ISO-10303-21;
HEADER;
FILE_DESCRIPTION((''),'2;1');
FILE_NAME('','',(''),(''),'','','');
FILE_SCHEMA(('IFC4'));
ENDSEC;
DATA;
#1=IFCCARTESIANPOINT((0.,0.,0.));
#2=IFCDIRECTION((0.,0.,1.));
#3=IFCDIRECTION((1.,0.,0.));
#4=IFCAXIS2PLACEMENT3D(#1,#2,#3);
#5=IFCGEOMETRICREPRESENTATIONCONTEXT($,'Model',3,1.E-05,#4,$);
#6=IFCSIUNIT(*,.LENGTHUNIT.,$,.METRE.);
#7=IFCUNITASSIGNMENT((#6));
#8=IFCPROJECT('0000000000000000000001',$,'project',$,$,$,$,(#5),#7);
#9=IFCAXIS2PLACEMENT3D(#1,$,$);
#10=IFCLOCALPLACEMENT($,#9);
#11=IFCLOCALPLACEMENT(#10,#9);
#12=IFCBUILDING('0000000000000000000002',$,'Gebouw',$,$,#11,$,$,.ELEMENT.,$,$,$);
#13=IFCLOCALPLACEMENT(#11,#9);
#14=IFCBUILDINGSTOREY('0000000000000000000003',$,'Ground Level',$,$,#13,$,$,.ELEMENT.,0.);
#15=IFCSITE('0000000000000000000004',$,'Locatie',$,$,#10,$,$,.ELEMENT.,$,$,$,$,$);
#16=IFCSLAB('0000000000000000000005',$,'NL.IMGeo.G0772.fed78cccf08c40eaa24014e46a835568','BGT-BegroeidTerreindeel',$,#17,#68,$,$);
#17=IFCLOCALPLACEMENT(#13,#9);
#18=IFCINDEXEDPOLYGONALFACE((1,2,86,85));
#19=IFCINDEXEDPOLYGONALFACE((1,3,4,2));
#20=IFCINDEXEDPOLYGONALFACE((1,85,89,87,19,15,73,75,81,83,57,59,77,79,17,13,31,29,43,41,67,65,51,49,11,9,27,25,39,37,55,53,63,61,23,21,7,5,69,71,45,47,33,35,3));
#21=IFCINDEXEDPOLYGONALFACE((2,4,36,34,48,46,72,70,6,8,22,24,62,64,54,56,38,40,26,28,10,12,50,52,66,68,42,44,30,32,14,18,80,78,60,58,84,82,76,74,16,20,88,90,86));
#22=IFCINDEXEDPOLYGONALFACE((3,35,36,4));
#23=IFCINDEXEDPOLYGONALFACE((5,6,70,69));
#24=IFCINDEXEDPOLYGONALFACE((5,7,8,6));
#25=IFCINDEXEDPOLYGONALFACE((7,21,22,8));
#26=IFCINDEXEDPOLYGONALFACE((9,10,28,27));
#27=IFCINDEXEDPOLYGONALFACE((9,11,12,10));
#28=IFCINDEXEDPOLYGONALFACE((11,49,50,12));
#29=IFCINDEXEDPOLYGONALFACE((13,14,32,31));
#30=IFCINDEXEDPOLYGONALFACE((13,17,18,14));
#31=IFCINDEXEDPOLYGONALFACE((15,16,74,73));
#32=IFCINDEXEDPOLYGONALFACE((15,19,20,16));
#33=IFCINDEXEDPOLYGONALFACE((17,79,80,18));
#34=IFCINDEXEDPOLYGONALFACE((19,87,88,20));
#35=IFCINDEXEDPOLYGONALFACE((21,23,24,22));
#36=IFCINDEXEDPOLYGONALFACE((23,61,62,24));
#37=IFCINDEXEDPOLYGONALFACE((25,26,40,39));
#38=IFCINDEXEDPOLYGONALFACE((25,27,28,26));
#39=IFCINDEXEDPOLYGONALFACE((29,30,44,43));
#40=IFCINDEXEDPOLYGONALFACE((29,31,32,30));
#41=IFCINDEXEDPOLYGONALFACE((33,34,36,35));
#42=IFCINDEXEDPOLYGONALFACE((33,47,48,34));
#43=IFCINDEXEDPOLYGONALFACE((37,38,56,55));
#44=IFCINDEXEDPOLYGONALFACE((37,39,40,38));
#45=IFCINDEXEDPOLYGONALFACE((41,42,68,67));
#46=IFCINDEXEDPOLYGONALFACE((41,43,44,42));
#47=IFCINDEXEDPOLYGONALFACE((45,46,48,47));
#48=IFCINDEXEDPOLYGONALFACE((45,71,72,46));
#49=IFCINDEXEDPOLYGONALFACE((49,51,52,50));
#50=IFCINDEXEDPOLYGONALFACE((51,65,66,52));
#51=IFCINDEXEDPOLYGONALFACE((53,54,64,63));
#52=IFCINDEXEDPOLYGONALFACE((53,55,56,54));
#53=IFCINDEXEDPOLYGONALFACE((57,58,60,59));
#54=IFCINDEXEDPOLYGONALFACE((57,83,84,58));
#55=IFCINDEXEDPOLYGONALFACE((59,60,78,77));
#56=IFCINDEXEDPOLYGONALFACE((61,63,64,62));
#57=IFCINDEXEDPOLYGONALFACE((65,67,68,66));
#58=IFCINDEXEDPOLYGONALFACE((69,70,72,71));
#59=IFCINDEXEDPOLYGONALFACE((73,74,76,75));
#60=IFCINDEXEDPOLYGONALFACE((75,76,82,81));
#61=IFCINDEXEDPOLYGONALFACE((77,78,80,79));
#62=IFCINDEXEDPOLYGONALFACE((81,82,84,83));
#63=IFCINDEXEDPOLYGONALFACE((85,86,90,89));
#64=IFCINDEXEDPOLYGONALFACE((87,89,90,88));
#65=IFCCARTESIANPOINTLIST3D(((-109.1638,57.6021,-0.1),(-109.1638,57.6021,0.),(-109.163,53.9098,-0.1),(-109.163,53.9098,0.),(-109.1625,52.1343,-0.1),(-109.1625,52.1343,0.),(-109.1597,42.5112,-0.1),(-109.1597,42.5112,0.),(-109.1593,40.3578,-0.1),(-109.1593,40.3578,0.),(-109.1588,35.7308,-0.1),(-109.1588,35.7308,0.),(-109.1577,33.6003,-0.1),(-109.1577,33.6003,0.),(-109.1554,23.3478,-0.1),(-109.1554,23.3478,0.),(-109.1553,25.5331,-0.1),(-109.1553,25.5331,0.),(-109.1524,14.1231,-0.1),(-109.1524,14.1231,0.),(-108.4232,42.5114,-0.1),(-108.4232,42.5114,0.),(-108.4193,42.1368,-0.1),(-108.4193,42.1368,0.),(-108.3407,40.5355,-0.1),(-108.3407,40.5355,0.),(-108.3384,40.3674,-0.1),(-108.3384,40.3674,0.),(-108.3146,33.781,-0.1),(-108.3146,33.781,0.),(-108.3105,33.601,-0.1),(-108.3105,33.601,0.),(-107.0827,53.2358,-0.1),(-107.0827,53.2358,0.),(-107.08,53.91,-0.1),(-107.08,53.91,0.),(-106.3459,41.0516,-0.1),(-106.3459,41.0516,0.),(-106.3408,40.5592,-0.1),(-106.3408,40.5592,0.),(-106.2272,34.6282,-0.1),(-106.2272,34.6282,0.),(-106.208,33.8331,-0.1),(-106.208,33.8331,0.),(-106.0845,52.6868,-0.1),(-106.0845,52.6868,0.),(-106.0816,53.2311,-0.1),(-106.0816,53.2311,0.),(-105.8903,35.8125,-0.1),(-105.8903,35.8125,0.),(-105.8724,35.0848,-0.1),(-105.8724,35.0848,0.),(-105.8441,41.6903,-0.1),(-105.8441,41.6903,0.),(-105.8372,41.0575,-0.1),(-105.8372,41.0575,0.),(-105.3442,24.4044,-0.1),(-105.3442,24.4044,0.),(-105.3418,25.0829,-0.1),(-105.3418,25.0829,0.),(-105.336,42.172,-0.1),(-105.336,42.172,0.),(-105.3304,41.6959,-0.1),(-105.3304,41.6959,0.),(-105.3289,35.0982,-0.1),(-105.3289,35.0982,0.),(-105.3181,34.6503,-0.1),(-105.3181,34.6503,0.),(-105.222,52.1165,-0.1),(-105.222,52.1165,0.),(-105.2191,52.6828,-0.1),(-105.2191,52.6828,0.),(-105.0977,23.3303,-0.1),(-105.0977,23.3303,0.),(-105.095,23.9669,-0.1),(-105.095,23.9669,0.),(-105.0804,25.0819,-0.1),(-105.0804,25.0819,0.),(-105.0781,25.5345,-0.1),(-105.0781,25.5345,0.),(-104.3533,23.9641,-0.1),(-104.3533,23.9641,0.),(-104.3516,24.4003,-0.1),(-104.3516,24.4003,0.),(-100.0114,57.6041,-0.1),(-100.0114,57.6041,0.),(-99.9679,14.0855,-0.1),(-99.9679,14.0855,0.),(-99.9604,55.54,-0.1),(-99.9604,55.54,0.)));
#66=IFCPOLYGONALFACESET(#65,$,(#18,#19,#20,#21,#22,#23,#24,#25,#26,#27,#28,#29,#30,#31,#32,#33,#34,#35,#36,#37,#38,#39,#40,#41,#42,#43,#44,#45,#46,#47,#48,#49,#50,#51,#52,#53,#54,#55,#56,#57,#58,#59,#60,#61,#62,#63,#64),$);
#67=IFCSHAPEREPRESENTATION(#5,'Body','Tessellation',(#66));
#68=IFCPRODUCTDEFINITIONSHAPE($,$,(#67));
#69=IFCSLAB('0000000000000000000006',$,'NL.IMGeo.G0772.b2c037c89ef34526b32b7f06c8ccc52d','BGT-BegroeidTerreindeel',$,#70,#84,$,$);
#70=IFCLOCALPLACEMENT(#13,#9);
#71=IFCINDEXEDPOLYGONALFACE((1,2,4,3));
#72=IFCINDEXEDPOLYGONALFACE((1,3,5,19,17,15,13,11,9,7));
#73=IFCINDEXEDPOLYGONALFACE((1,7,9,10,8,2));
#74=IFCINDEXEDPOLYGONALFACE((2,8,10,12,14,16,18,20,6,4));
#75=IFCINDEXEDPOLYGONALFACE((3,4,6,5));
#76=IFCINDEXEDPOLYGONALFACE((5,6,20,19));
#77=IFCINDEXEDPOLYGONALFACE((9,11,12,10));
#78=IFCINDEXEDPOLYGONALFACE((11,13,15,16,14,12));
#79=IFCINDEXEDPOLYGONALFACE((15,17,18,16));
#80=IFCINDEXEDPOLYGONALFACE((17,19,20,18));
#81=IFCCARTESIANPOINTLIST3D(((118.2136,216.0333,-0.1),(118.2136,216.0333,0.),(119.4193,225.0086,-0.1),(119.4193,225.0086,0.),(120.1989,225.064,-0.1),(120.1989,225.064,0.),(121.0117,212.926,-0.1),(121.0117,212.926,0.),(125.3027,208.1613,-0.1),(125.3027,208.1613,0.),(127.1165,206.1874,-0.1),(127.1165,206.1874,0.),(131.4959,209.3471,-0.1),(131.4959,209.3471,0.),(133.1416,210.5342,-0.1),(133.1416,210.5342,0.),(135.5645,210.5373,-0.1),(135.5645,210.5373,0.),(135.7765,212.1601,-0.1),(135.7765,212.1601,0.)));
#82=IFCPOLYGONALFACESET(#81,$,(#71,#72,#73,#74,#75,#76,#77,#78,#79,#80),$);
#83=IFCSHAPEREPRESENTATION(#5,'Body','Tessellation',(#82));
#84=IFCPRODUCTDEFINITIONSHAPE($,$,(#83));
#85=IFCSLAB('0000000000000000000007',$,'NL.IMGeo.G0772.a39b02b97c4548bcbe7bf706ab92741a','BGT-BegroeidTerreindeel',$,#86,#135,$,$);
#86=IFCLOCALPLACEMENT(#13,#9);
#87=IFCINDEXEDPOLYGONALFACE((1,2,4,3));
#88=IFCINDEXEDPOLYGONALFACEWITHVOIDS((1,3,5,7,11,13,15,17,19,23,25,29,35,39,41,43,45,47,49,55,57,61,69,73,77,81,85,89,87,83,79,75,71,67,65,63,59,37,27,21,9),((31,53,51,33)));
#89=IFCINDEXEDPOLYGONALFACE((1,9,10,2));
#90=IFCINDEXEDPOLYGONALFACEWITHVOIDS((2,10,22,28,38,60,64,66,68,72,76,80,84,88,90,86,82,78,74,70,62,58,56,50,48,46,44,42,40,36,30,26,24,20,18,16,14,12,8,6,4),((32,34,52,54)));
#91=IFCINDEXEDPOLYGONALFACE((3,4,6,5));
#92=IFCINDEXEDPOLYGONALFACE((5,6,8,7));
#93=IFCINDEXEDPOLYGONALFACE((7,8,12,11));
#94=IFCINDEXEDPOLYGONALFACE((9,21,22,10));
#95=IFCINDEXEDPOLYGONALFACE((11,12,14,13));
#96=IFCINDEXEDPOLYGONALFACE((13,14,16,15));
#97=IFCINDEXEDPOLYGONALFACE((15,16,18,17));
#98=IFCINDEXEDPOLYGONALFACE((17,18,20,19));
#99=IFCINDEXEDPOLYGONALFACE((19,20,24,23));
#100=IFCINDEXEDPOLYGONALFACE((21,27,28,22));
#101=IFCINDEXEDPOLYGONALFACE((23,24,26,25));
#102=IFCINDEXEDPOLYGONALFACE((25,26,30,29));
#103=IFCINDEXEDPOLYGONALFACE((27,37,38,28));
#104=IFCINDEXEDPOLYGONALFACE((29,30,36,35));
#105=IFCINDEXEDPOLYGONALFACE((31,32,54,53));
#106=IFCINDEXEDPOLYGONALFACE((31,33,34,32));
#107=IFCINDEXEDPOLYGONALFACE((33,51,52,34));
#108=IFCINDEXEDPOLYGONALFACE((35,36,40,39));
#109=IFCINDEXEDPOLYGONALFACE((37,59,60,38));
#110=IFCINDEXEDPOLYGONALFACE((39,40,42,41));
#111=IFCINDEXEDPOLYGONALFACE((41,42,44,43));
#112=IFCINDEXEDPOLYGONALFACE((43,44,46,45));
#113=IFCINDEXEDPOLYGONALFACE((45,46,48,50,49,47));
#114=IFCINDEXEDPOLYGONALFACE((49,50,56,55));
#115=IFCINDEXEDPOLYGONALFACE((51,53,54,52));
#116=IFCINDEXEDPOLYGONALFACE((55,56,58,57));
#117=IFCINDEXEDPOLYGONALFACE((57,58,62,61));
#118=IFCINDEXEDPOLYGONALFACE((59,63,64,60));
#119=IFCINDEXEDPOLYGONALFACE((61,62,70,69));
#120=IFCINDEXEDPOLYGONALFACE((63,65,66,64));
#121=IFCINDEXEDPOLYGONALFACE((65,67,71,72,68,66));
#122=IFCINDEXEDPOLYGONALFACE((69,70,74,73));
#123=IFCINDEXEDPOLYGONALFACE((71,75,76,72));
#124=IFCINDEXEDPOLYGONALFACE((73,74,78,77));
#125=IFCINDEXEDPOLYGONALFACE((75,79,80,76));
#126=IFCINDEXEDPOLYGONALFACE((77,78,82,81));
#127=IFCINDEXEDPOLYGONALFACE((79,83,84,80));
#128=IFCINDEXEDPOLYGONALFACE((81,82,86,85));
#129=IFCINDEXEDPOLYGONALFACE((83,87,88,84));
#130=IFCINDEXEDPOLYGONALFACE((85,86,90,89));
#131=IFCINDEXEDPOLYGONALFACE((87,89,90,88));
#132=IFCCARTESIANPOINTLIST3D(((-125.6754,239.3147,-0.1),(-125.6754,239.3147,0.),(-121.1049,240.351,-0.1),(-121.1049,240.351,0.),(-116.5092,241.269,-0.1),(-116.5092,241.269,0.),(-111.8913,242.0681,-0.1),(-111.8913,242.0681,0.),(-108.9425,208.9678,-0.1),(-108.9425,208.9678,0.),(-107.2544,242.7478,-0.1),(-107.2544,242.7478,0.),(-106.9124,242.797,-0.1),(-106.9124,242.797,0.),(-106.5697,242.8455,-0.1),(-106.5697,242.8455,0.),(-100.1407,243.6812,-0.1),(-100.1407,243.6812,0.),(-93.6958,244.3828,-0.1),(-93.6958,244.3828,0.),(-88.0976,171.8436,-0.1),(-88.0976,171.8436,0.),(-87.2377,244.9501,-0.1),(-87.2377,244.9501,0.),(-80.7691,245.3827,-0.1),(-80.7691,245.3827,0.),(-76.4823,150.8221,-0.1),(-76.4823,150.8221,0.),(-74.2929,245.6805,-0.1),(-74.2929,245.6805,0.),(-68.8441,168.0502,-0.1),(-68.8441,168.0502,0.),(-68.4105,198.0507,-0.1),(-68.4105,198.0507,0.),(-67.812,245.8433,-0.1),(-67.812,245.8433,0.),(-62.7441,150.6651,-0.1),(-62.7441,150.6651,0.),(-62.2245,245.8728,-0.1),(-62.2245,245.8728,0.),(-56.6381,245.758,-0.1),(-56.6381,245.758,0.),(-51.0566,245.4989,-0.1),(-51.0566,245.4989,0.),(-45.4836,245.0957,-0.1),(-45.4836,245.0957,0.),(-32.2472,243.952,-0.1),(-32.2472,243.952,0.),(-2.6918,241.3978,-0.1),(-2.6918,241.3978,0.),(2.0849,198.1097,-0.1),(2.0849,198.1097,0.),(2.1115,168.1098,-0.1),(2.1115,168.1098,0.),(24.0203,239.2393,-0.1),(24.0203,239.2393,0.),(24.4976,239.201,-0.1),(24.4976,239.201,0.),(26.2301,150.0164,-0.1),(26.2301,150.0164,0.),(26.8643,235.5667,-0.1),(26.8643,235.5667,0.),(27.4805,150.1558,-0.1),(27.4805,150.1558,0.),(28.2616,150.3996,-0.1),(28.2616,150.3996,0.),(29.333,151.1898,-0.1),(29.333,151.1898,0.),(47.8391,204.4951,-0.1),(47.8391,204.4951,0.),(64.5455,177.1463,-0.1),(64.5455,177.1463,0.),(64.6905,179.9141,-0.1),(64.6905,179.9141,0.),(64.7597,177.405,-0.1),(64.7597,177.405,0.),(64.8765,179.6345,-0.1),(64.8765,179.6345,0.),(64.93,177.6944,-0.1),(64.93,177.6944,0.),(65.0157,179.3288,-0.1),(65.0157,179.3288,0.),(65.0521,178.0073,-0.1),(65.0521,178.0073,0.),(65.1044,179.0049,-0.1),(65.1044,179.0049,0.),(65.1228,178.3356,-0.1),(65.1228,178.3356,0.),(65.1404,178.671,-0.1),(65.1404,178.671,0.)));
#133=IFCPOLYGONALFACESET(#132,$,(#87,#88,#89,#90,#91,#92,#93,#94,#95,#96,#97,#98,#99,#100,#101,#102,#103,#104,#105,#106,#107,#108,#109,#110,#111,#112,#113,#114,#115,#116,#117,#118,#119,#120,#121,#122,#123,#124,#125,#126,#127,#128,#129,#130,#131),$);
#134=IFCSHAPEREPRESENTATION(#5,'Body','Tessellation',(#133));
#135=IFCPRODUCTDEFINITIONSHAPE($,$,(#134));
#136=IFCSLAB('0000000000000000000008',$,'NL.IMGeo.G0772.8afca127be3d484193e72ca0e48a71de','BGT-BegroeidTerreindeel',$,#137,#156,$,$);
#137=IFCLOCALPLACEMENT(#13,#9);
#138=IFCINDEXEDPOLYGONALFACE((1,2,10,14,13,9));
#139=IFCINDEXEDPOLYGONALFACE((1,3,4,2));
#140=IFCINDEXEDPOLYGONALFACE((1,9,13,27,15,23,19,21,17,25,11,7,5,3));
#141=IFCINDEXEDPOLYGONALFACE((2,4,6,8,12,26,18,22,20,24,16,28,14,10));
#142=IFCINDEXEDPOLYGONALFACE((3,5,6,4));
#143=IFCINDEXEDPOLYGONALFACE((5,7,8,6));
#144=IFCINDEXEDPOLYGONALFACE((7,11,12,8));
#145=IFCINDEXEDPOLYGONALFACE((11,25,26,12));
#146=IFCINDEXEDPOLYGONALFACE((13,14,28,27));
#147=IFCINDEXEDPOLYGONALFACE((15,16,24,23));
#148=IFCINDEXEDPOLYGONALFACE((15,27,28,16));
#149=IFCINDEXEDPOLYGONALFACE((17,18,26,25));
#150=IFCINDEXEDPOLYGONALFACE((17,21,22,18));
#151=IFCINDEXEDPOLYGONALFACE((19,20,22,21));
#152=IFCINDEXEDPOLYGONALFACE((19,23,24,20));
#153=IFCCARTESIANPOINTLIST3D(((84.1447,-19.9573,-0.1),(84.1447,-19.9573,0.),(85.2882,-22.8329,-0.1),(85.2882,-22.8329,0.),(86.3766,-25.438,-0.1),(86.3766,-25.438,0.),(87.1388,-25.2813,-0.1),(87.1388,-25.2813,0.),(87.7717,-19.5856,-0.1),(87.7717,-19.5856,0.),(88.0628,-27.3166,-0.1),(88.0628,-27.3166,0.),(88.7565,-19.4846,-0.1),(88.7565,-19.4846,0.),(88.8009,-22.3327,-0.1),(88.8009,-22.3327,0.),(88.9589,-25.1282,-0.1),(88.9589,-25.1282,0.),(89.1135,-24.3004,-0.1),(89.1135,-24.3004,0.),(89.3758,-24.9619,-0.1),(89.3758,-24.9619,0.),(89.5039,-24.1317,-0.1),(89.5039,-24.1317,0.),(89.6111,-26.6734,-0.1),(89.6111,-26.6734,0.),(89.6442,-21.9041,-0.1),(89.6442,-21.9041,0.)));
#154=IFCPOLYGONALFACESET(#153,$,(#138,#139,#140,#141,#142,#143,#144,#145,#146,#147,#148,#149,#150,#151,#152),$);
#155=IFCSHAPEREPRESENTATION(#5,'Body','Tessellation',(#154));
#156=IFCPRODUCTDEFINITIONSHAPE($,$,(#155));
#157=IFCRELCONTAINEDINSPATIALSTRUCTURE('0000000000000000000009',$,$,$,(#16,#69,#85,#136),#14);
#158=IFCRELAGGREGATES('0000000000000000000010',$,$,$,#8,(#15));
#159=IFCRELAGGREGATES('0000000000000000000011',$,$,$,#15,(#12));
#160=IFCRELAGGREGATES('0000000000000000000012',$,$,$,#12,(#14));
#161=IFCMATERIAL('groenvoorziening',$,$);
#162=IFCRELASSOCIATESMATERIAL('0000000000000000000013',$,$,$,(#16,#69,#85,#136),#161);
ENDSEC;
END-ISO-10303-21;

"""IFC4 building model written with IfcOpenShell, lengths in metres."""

from ifc_helpers import new_model, si_unit, frame, origin, origin_with_axes, place, context, project, spatial, polyline, outline, extrude, material, element, save


model = new_model("IFC4")

# Units and contexts
model_context = context("Model", 3, precision=1e-05, world=origin_with_axes())
ifc_project = project(units=[si_unit("LENGTHUNIT", "METRE")], contexts=[model_context])

# Site, building, storey
site_placement = place(None, origin())
site = spatial("IfcSite", under=ifc_project, at=site_placement, Name="Locatie", CompositionType="ELEMENT")
building_placement = place(site_placement, origin())
building = spatial("IfcBuilding", under=site, at=building_placement, Name="Gebouw", CompositionType="ELEMENT")
storey_placement = place(building_placement, origin())
storey = spatial("IfcBuildingStorey", under=building, at=storey_placement, Name="Ground Level", CompositionType="ELEMENT", Elevation=0.0)

# Slabs
ifc_material = material(Name="groenvoorziening")
slab_1_placement = place(storey_placement, origin())
element("IfcSlab", 1, at=slab_1_placement, inside=storey, material=ifc_material, Name="NL.IMGeo.G0772.fed78cccf08c40eaa24014e46a835568", Description="BGT-BegroeidTerreindeel", context=model_context, shape_type="SweptSolid", body=[
    extrude(outline(polyline([(-99.9679, 14.0855), (-109.1524, 14.1231), (-109.1554, 23.3478), (-105.0977, 23.3303), (-105.095, 23.9669), (-104.3533, 23.9641), (-104.3516, 24.4003), (-105.3442, 24.4044), (-105.3418, 25.0829), (-105.0804, 25.0819), (-105.0781, 25.5345), (-109.1553, 25.5331), (-109.1577, 33.6003), (-108.3105, 33.601), (-108.3146, 33.781), (-106.208, 33.8331), (-106.2272, 34.6282), (-105.3181, 34.6503), (-105.3289, 35.0982), (-105.8724, 35.0848), (-105.8903, 35.8125), (-109.1588, 35.7308), (-109.1593, 40.3578), (-108.3384, 40.3674), (-108.3407, 40.5355), (-106.3408, 40.5592), (-106.3459, 41.0516), (-105.8372, 41.0575), (-105.8441, 41.6903), (-105.3304, 41.6959), (-105.336, 42.172), (-108.4193, 42.1368), (-108.4232, 42.5114), (-109.1597, 42.5112), (-109.1625, 52.1343), (-105.222, 52.1165), (-105.2191, 52.6828), (-106.0845, 52.6868), (-106.0816, 53.2311), (-107.0827, 53.2358), (-107.08, 53.91), (-109.163, 53.9098), (-109.1638, 57.6021), (-100.0114, 57.6041), (-99.9604, 55.54), (-99.9679, 14.0855)])), frame((0.0, 0.0, -0.1), z_axis=(0.0, 0.0, 1.0), x_axis=(1.0, 0.0, 0.0)), (0.0, 0.0, 1.0), 0.1),
])
slab_2_placement = place(storey_placement, origin())
element("IfcSlab", 2, at=slab_2_placement, inside=storey, material=ifc_material, Name="NL.IMGeo.G0772.b2c037c89ef34526b32b7f06c8ccc52d", Description="BGT-BegroeidTerreindeel", context=model_context, shape_type="SweptSolid", body=[
    extrude(outline(polyline([(135.5645, 210.5373), (133.1416, 210.5342), (131.4959, 209.3471), (127.1165, 206.1874), (125.3027, 208.1613), (121.0117, 212.926), (118.2136, 216.0333), (119.4193, 225.0086), (120.1989, 225.064), (135.7765, 212.1601), (135.5645, 210.5373)])), frame((0.0, 0.0, -0.1), z_axis=(0.0, 0.0, 1.0), x_axis=(1.0, 0.0, 0.0)), (0.0, 0.0, 1.0), 0.1),
])
slab_3_placement = place(storey_placement, origin())
element("IfcSlab", 3, at=slab_3_placement, inside=storey, material=ifc_material, Name="NL.IMGeo.G0772.a39b02b97c4548bcbe7bf706ab92741a", Description="BGT-BegroeidTerreindeel", context=model_context, shape_type="SweptSolid", body=[
    extrude(outline(polyline([(-2.6918, 241.3978), (24.0203, 239.2393), (24.4976, 239.201), (26.8643, 235.5667), (47.8391, 204.4951), (64.6905, 179.9141), (64.8765, 179.6345), (65.0157, 179.3288), (65.1044, 179.0049), (65.1404, 178.671), (65.1228, 178.3356), (65.0521, 178.0073), (64.93, 177.6944), (64.7597, 177.405), (64.5455, 177.1463), (29.333, 151.1898), (28.2616, 150.3996), (27.4805, 150.1558), (26.2301, 150.0164), (-62.7441, 150.6651), (-76.4823, 150.8221), (-88.0976, 171.8436), (-108.9425, 208.9678), (-125.6754, 239.3147), (-121.1049, 240.351), (-116.5092, 241.269), (-111.8913, 242.0681), (-107.2544, 242.7478), (-106.9124, 242.797), (-106.5697, 242.8455), (-100.1407, 243.6812), (-93.6958, 244.3828), (-87.2377, 244.9501), (-80.7691, 245.3827), (-74.2929, 245.6805), (-67.812, 245.8433), (-62.2245, 245.8728), (-56.6381, 245.758), (-51.0566, 245.4989), (-45.4836, 245.0957), (-32.2472, 243.952), (-2.6918, 241.3978)]), holes=[polyline([(-68.4105, 198.0507), (-68.8441, 168.0502), (2.1115, 168.1098), (2.0849, 198.1097), (-68.4105, 198.0507)])]), frame((0.0, 0.0, -0.1), z_axis=(0.0, 0.0, 1.0), x_axis=(1.0, 0.0, 0.0)), (0.0, 0.0, 1.0), 0.1),
])
slab_4_placement = place(storey_placement, origin())
element("IfcSlab", 4, at=slab_4_placement, inside=storey, material=ifc_material, Name="NL.IMGeo.G0772.8afca127be3d484193e72ca0e48a71de", Description="BGT-BegroeidTerreindeel", context=model_context, shape_type="SweptSolid", body=[
    extrude(outline(polyline([(89.6442, -21.9041), (88.8009, -22.3327), (89.5039, -24.1317), (89.1135, -24.3004), (89.3758, -24.9619), (88.9589, -25.1282), (89.6111, -26.6734), (88.0628, -27.3166), (87.1388, -25.2813), (86.3766, -25.438), (85.2882, -22.8329), (84.1447, -19.9573), (87.7717, -19.5856), (88.7565, -19.4846), (89.6442, -21.9041)])), frame((0.0, 0.0, -0.1), z_axis=(0.0, 0.0, 1.0), x_axis=(1.0, 0.0, 0.0)), (0.0, 0.0, 1.0), 0.1),
])

save(model, "model.ifc")
